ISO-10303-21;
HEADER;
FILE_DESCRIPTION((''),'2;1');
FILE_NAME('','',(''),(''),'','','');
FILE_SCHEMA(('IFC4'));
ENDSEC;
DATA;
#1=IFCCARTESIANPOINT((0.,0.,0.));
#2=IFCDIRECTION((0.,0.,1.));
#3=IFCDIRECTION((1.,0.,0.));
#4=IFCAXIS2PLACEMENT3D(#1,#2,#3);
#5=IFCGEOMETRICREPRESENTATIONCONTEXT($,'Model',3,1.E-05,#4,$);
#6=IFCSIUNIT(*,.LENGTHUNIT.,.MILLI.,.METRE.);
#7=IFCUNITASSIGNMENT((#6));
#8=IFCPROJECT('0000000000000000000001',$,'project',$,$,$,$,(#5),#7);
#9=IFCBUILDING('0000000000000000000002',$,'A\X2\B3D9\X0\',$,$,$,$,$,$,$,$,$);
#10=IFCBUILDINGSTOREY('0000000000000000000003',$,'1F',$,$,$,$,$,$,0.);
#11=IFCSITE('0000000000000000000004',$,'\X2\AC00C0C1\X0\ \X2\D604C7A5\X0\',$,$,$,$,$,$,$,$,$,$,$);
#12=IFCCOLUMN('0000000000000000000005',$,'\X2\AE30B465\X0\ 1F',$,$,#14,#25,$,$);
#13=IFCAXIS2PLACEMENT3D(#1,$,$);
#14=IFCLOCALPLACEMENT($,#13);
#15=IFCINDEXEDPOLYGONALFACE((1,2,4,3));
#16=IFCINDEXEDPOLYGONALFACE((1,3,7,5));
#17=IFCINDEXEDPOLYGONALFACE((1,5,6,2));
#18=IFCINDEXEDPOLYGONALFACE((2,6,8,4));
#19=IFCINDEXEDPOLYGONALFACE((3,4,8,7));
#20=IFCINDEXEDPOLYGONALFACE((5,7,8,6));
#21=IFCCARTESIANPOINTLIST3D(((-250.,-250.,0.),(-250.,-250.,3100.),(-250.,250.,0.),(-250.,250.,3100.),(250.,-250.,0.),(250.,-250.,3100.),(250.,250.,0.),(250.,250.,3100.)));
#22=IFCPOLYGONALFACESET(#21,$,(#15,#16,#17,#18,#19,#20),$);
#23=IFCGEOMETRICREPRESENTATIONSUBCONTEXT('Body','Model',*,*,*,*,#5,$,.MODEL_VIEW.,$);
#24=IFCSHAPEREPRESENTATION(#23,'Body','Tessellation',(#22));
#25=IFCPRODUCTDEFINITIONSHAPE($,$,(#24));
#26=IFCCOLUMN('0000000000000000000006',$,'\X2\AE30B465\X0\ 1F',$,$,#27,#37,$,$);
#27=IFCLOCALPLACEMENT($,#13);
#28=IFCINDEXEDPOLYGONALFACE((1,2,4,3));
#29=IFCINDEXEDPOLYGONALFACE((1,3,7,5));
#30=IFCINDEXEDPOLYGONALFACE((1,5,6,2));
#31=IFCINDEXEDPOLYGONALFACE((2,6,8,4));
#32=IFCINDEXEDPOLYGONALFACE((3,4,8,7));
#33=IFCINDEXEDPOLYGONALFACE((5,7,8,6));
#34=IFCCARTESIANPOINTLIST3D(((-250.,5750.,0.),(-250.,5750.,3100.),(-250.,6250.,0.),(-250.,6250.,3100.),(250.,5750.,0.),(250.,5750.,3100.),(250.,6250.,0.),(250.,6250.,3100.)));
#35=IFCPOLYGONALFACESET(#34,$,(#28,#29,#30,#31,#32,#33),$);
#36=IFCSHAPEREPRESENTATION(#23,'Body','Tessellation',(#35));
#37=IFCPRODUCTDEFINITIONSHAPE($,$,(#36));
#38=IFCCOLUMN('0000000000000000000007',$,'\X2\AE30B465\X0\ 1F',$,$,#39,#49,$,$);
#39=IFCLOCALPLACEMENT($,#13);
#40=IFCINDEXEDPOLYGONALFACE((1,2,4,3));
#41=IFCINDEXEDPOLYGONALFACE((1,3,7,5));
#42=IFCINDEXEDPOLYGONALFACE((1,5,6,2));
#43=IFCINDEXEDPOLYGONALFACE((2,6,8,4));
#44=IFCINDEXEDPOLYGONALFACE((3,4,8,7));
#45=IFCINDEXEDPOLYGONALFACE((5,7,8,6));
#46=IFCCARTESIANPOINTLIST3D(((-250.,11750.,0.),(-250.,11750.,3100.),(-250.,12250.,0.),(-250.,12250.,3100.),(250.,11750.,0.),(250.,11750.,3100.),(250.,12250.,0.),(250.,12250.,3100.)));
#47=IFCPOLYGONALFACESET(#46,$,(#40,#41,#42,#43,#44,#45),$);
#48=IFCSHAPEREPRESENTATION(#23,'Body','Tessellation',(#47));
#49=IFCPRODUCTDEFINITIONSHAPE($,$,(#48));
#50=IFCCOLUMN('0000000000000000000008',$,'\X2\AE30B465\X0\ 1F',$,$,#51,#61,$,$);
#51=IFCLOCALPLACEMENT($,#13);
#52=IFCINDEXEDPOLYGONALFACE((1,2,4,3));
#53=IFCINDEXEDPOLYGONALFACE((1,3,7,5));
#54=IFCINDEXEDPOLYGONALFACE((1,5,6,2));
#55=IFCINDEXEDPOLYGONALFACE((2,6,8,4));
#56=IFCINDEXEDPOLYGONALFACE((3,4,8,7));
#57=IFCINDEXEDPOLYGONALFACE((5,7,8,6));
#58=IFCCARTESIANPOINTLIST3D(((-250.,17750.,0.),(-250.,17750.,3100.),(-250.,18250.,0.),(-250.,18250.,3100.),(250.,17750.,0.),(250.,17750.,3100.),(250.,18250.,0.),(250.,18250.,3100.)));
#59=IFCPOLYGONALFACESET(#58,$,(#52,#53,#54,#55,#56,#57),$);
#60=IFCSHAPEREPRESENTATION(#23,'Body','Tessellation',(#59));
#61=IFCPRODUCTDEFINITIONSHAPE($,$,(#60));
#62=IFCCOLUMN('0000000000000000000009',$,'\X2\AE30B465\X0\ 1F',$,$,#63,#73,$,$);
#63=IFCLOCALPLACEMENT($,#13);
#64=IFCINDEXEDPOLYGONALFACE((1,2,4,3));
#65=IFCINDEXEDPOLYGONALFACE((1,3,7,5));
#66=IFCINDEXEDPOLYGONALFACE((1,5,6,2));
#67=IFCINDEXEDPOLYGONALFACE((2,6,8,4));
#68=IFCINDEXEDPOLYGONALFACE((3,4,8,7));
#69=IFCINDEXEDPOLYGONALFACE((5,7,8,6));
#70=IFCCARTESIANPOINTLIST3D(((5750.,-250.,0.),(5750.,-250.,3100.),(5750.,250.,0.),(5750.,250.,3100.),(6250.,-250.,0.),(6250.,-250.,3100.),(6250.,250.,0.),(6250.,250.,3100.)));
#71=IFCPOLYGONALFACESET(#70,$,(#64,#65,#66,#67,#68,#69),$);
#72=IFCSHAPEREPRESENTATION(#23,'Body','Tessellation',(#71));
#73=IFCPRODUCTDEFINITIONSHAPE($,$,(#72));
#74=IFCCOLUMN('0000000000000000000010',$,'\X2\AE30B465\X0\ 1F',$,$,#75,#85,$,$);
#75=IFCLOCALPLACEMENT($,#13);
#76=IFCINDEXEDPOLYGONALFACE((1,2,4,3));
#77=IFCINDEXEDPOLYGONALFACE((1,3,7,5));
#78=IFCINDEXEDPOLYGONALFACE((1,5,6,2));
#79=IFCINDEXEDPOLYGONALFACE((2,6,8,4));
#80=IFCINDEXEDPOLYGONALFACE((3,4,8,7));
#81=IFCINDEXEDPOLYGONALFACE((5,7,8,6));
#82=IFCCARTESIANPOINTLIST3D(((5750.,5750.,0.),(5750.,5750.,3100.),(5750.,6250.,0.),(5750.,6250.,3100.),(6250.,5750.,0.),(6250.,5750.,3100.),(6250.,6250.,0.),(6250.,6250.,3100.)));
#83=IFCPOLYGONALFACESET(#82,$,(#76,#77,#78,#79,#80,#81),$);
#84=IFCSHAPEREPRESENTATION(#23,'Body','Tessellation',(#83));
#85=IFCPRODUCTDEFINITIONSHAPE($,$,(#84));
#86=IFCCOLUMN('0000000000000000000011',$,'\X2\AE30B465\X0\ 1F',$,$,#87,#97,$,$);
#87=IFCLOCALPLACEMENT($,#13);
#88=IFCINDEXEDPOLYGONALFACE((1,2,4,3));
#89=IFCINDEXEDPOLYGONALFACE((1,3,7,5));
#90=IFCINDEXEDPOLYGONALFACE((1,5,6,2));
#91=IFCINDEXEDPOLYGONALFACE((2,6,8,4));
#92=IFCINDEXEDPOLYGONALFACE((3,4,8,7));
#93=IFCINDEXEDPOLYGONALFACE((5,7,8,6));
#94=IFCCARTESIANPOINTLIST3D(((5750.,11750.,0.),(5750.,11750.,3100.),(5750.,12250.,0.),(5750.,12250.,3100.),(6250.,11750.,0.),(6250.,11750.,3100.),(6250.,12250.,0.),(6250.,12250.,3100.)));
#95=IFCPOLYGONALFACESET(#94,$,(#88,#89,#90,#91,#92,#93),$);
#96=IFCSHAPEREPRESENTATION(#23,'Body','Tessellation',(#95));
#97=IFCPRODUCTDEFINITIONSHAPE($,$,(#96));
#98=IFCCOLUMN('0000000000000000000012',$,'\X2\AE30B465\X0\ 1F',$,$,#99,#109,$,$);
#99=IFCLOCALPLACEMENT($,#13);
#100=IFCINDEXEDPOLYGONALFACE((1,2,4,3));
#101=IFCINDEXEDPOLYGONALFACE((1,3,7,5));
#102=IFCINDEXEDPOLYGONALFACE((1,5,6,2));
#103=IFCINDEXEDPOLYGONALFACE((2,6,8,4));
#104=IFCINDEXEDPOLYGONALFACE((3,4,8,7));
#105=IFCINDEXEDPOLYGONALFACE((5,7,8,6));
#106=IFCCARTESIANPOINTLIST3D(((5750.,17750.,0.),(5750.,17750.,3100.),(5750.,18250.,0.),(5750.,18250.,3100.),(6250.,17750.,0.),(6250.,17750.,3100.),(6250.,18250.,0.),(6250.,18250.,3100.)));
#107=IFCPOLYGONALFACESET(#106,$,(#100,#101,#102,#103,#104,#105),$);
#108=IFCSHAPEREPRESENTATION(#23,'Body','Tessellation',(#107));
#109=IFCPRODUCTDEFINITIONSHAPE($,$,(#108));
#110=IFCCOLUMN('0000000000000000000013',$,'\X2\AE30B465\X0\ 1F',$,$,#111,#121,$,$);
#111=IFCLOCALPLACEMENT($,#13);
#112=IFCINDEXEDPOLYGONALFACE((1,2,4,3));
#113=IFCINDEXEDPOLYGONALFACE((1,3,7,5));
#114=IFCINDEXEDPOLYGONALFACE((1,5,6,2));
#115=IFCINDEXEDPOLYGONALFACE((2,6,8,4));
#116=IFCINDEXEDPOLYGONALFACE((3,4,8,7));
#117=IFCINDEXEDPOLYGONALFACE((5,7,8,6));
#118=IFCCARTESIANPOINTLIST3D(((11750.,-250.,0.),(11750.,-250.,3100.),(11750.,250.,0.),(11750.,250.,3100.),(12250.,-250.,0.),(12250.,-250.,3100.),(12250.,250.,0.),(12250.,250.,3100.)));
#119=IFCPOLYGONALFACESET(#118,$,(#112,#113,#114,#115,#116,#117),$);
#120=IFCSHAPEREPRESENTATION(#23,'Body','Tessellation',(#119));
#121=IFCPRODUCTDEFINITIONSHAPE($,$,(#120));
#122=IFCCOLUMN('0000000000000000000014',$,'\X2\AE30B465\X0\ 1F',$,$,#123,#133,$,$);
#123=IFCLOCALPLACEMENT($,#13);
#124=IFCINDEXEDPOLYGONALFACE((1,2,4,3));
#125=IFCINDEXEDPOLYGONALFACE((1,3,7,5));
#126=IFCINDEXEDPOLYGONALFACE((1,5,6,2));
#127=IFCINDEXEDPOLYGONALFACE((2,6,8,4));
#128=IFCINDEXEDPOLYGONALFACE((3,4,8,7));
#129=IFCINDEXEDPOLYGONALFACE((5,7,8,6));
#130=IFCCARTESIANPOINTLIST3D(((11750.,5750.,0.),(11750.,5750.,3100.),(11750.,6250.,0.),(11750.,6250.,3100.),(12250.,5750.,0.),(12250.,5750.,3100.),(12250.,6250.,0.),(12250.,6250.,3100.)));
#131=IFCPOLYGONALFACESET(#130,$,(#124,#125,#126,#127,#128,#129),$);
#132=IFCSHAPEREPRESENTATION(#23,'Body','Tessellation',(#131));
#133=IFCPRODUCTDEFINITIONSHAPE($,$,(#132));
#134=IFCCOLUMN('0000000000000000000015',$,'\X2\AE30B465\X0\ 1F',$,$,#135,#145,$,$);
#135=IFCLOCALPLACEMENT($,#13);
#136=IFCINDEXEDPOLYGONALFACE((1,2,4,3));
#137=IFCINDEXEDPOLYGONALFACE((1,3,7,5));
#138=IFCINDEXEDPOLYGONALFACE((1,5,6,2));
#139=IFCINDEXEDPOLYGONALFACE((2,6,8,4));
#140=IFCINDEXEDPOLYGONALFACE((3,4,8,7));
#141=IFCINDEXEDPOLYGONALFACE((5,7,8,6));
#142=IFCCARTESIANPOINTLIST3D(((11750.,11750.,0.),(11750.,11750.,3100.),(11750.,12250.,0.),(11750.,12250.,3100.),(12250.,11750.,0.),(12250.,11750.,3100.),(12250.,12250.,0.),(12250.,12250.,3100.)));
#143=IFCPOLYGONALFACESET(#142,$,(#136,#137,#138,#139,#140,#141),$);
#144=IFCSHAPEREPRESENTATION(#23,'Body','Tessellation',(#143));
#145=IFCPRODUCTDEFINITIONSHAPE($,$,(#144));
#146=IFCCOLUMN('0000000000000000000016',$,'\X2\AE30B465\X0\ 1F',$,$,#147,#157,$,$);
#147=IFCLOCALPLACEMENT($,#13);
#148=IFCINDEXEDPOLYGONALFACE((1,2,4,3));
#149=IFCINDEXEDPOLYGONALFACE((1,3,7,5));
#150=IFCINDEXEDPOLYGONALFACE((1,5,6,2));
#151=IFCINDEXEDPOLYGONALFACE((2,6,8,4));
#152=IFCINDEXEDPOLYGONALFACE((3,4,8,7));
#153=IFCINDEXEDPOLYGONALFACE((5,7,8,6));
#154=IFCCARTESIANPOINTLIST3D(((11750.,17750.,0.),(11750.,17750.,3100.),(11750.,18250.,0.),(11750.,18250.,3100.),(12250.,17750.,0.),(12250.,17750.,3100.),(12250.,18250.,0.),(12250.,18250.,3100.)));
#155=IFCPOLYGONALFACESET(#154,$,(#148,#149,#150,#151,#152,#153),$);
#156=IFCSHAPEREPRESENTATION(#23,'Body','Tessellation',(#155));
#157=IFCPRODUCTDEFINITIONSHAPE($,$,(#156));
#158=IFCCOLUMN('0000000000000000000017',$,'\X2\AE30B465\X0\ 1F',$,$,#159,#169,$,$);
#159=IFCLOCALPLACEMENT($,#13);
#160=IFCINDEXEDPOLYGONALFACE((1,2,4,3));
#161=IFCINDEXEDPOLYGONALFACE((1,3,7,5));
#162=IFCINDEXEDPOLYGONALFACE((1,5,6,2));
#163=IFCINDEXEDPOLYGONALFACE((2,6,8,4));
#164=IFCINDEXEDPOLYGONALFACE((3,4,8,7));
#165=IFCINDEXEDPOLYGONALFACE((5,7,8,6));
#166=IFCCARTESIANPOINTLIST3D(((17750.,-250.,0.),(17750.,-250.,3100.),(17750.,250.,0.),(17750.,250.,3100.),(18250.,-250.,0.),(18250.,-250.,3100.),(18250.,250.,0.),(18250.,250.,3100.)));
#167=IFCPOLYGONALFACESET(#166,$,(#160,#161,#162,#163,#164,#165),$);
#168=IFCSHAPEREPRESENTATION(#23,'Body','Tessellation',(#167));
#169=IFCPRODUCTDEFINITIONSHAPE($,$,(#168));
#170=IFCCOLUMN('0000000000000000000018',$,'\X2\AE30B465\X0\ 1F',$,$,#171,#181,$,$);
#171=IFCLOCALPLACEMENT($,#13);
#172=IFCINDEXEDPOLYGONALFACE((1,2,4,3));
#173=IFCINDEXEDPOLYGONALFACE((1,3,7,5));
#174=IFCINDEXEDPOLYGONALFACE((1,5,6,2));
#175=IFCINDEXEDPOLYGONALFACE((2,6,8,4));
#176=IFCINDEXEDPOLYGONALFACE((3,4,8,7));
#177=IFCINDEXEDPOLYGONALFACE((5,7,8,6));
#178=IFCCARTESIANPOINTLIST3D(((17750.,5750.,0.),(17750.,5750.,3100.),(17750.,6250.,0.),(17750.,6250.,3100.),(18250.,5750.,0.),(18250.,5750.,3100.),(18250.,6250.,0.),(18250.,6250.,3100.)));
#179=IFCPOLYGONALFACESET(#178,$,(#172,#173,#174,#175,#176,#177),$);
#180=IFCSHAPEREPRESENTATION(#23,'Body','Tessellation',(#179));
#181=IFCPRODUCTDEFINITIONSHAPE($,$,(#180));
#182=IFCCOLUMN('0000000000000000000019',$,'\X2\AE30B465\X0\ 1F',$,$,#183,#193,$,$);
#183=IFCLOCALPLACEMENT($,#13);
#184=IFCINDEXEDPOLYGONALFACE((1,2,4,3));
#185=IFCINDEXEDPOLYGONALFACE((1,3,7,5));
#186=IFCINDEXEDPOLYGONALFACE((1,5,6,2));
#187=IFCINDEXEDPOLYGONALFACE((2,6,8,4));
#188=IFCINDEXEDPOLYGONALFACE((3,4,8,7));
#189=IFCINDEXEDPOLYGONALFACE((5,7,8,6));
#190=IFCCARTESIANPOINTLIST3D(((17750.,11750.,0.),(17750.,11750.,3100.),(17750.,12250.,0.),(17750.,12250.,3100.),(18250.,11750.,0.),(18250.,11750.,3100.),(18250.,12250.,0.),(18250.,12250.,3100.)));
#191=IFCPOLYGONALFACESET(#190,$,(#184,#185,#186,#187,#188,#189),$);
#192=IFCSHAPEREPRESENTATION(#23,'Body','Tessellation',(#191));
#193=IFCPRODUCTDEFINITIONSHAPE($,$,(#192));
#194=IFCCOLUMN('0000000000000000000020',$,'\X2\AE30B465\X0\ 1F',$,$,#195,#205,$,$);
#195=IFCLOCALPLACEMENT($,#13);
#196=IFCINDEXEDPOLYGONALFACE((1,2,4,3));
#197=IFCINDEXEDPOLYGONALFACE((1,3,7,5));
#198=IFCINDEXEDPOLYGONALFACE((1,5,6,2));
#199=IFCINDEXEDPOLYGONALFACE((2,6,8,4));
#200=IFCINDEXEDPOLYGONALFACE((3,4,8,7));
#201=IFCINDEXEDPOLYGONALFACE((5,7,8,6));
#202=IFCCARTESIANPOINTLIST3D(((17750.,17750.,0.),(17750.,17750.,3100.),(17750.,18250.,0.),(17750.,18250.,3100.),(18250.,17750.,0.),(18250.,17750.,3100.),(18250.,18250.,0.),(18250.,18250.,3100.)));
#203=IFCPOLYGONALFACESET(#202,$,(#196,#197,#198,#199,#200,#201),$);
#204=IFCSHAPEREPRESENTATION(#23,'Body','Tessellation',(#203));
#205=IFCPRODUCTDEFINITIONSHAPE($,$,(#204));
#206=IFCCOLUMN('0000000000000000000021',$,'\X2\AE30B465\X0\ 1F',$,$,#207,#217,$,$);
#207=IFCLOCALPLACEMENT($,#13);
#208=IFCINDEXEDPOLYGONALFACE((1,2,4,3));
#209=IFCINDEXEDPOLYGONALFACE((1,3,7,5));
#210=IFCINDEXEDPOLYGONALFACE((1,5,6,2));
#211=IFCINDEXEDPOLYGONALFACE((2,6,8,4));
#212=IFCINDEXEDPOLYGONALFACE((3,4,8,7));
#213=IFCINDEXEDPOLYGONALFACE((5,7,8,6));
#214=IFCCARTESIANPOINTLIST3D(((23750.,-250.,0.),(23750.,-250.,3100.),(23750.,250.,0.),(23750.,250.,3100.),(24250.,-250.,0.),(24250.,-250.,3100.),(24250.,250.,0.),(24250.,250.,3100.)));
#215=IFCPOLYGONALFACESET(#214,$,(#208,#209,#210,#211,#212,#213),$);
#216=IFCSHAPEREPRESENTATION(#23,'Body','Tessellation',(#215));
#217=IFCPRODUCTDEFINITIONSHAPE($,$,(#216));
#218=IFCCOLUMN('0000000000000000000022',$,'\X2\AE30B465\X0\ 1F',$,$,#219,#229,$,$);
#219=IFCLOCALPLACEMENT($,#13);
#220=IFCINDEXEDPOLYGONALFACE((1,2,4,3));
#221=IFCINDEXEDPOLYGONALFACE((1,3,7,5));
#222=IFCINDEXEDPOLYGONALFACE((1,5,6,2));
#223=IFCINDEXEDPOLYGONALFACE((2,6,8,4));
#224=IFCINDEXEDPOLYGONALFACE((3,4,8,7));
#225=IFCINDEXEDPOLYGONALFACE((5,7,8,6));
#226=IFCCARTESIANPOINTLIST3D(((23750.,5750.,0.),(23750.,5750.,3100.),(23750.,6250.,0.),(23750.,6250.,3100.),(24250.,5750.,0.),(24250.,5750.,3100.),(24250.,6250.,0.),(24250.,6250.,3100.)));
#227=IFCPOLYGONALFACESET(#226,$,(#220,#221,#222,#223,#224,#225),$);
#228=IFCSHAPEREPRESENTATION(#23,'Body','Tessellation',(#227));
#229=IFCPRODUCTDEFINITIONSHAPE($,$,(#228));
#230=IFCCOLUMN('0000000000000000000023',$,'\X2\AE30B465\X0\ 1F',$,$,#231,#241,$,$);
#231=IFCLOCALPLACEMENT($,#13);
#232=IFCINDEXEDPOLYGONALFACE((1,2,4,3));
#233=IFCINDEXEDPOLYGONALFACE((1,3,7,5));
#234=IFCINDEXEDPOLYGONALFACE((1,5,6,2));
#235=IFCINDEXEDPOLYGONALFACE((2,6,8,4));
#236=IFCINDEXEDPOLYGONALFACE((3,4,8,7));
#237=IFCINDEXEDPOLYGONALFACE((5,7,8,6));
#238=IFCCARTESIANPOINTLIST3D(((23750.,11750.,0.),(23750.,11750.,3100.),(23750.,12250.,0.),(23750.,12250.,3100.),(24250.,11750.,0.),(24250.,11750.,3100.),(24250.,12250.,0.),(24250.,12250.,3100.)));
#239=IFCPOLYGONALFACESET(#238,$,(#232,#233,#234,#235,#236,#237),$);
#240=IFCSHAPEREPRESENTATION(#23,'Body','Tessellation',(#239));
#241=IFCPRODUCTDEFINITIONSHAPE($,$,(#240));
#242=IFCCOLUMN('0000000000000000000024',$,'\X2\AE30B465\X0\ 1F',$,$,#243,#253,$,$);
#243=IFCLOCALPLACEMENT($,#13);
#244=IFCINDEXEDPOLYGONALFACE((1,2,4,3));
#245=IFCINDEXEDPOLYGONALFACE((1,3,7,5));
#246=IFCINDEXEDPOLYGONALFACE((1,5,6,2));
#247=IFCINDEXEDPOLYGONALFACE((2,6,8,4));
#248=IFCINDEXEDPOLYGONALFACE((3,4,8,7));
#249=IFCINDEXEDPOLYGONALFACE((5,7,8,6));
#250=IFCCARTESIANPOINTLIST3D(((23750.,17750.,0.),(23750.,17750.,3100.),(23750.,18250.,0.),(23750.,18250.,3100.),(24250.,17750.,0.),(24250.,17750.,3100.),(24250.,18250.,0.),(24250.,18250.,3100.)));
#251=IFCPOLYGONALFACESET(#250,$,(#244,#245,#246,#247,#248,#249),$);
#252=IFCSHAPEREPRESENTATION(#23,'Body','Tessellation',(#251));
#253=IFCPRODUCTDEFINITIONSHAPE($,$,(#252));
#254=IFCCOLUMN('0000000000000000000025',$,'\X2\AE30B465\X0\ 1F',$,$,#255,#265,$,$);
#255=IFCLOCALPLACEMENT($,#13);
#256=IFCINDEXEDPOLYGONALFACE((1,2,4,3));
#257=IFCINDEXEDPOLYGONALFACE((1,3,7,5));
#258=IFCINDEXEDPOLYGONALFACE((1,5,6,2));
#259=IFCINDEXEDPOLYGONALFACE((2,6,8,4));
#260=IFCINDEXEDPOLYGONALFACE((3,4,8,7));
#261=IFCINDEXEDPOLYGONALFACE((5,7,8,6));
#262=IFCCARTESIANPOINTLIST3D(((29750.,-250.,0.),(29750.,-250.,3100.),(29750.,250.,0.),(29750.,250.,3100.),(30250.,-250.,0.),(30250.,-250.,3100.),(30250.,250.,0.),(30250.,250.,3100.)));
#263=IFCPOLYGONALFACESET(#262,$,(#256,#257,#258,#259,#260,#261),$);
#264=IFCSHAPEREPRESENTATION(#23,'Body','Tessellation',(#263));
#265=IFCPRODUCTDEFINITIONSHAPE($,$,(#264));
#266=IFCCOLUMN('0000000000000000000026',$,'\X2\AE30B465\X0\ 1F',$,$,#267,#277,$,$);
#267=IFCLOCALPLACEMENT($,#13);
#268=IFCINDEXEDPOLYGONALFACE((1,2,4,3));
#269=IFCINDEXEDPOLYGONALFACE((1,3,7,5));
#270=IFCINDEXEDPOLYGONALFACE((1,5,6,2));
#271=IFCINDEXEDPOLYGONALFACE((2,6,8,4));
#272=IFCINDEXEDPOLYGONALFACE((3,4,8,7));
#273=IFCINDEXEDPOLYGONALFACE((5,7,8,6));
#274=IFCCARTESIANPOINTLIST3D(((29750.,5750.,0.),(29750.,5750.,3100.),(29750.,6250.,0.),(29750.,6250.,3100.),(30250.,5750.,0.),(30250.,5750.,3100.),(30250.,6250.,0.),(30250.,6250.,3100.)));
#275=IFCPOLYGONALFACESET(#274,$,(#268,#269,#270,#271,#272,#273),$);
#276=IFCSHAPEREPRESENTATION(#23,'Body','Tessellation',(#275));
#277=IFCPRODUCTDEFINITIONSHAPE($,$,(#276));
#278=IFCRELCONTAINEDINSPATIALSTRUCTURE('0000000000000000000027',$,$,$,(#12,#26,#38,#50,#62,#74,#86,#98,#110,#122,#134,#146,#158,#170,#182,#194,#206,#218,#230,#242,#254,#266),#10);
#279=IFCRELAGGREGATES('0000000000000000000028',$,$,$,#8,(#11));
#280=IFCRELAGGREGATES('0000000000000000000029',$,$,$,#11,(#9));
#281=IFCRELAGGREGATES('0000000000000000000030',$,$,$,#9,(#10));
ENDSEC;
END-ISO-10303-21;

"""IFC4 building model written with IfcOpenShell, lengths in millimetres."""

from ifc_helpers import new_model, si_unit, frame, origin_with_axes, place, context, subcontext, project, spatial, indexed_curve, outline, extrude, element, save


model = new_model("IFC4")

# Units and contexts
model_context = context("Model", 3, precision=1e-05, world=origin_with_axes())
body_context = subcontext(model_context, "Body", "Model", "MODEL_VIEW")
ifc_project = project(units=[si_unit("LENGTHUNIT", "METRE", prefix="MILLI")], contexts=[model_context])

# Site, building, storey
site = spatial("IfcSite", under=ifc_project, Name="가상 현장")
building = spatial("IfcBuilding", under=site, Name="A동")
storey = spatial("IfcBuildingStorey", under=building, Name="1F", Elevation=0.0)

# Columns
for number, where, z_axis, x_axis, name in (
    (1, (-250.0, -250.0, 0.0), (0.0, 0.0, 1.0), (1.0, 0.0, 0.0), "기둥 1F"),
    (2, (-250.0, 5750.0, 0.0), (0.0, 0.0, 1.0), (1.0, 0.0, 0.0), "기둥 1F"),
    (3, (-250.0, 11750.0, 0.0), (0.0, 0.0, 1.0), (1.0, 0.0, 0.0), "기둥 1F"),
    (4, (-250.0, 17750.0, 0.0), (0.0, 0.0, 1.0), (1.0, 0.0, 0.0), "기둥 1F"),
    (5, (5750.0, -250.0, 0.0), (0.0, 0.0, 1.0), (1.0, 0.0, 0.0), "기둥 1F"),
    (6, (5750.0, 5750.0, 0.0), (0.0, 0.0, 1.0), (1.0, 0.0, 0.0), "기둥 1F"),
    (7, (5750.0, 11750.0, 0.0), (0.0, 0.0, 1.0), (1.0, 0.0, 0.0), "기둥 1F"),
    (8, (5750.0, 17750.0, 0.0), (0.0, 0.0, 1.0), (1.0, 0.0, 0.0), "기둥 1F"),
    (9, (11750.0, -250.0, 0.0), (0.0, 0.0, 1.0), (1.0, 0.0, 0.0), "기둥 1F"),
    (10, (11750.0, 5750.0, 0.0), (0.0, 0.0, 1.0), (1.0, 0.0, 0.0), "기둥 1F"),
    (11, (11750.0, 11750.0, 0.0), (0.0, 0.0, 1.0), (1.0, 0.0, 0.0), "기둥 1F"),
    (12, (11750.0, 17750.0, 0.0), (0.0, 0.0, 1.0), (1.0, 0.0, 0.0), "기둥 1F"),
    (13, (17750.0, -250.0, 0.0), (0.0, 0.0, 1.0), (1.0, 0.0, 0.0), "기둥 1F"),
    (14, (17750.0, 5750.0, 0.0), (0.0, 0.0, 1.0), (1.0, 0.0, 0.0), "기둥 1F"),
    (15, (17750.0, 11750.0, 0.0), (0.0, 0.0, 1.0), (1.0, 0.0, 0.0), "기둥 1F"),
    (16, (17750.0, 17750.0, 0.0), (0.0, 0.0, 1.0), (1.0, 0.0, 0.0), "기둥 1F"),
    (17, (23750.0, -250.0, 0.0), (0.0, 0.0, 1.0), (1.0, 0.0, 0.0), "기둥 1F"),
    (18, (23750.0, 5750.0, 0.0), (0.0, 0.0, 1.0), (1.0, 0.0, 0.0), "기둥 1F"),
    (19, (23750.0, 11750.0, 0.0), (0.0, 0.0, 1.0), (1.0, 0.0, 0.0), "기둥 1F"),
    (20, (23750.0, 17750.0, 0.0), (0.0, 0.0, 1.0), (1.0, 0.0, 0.0), "기둥 1F"),
    (21, (29750.0, -250.0, 0.0), (0.0, 0.0, 1.0), (1.0, 0.0, 0.0), "기둥 1F"),
    (22, (29750.0, 5750.0, 0.0), (0.0, 0.0, 1.0), (1.0, 0.0, 0.0), "기둥 1F"),
):
    element("IfcColumn", number, at=place(None, frame(where, z_axis=z_axis, x_axis=x_axis)), inside=storey, Name=name, context=body_context, shape_type="SweptSolid", body=[
        extrude(outline(indexed_curve([(0.0, 0.0), (0.0, 500.0), (500.0, 500.0), (500.0, 0.0), (0.0, 0.0)], self_intersect=False)), origin_with_axes(), (0.0, 0.0, 1.0), 3100.0),
    ])

save(model, "model.ifc")
